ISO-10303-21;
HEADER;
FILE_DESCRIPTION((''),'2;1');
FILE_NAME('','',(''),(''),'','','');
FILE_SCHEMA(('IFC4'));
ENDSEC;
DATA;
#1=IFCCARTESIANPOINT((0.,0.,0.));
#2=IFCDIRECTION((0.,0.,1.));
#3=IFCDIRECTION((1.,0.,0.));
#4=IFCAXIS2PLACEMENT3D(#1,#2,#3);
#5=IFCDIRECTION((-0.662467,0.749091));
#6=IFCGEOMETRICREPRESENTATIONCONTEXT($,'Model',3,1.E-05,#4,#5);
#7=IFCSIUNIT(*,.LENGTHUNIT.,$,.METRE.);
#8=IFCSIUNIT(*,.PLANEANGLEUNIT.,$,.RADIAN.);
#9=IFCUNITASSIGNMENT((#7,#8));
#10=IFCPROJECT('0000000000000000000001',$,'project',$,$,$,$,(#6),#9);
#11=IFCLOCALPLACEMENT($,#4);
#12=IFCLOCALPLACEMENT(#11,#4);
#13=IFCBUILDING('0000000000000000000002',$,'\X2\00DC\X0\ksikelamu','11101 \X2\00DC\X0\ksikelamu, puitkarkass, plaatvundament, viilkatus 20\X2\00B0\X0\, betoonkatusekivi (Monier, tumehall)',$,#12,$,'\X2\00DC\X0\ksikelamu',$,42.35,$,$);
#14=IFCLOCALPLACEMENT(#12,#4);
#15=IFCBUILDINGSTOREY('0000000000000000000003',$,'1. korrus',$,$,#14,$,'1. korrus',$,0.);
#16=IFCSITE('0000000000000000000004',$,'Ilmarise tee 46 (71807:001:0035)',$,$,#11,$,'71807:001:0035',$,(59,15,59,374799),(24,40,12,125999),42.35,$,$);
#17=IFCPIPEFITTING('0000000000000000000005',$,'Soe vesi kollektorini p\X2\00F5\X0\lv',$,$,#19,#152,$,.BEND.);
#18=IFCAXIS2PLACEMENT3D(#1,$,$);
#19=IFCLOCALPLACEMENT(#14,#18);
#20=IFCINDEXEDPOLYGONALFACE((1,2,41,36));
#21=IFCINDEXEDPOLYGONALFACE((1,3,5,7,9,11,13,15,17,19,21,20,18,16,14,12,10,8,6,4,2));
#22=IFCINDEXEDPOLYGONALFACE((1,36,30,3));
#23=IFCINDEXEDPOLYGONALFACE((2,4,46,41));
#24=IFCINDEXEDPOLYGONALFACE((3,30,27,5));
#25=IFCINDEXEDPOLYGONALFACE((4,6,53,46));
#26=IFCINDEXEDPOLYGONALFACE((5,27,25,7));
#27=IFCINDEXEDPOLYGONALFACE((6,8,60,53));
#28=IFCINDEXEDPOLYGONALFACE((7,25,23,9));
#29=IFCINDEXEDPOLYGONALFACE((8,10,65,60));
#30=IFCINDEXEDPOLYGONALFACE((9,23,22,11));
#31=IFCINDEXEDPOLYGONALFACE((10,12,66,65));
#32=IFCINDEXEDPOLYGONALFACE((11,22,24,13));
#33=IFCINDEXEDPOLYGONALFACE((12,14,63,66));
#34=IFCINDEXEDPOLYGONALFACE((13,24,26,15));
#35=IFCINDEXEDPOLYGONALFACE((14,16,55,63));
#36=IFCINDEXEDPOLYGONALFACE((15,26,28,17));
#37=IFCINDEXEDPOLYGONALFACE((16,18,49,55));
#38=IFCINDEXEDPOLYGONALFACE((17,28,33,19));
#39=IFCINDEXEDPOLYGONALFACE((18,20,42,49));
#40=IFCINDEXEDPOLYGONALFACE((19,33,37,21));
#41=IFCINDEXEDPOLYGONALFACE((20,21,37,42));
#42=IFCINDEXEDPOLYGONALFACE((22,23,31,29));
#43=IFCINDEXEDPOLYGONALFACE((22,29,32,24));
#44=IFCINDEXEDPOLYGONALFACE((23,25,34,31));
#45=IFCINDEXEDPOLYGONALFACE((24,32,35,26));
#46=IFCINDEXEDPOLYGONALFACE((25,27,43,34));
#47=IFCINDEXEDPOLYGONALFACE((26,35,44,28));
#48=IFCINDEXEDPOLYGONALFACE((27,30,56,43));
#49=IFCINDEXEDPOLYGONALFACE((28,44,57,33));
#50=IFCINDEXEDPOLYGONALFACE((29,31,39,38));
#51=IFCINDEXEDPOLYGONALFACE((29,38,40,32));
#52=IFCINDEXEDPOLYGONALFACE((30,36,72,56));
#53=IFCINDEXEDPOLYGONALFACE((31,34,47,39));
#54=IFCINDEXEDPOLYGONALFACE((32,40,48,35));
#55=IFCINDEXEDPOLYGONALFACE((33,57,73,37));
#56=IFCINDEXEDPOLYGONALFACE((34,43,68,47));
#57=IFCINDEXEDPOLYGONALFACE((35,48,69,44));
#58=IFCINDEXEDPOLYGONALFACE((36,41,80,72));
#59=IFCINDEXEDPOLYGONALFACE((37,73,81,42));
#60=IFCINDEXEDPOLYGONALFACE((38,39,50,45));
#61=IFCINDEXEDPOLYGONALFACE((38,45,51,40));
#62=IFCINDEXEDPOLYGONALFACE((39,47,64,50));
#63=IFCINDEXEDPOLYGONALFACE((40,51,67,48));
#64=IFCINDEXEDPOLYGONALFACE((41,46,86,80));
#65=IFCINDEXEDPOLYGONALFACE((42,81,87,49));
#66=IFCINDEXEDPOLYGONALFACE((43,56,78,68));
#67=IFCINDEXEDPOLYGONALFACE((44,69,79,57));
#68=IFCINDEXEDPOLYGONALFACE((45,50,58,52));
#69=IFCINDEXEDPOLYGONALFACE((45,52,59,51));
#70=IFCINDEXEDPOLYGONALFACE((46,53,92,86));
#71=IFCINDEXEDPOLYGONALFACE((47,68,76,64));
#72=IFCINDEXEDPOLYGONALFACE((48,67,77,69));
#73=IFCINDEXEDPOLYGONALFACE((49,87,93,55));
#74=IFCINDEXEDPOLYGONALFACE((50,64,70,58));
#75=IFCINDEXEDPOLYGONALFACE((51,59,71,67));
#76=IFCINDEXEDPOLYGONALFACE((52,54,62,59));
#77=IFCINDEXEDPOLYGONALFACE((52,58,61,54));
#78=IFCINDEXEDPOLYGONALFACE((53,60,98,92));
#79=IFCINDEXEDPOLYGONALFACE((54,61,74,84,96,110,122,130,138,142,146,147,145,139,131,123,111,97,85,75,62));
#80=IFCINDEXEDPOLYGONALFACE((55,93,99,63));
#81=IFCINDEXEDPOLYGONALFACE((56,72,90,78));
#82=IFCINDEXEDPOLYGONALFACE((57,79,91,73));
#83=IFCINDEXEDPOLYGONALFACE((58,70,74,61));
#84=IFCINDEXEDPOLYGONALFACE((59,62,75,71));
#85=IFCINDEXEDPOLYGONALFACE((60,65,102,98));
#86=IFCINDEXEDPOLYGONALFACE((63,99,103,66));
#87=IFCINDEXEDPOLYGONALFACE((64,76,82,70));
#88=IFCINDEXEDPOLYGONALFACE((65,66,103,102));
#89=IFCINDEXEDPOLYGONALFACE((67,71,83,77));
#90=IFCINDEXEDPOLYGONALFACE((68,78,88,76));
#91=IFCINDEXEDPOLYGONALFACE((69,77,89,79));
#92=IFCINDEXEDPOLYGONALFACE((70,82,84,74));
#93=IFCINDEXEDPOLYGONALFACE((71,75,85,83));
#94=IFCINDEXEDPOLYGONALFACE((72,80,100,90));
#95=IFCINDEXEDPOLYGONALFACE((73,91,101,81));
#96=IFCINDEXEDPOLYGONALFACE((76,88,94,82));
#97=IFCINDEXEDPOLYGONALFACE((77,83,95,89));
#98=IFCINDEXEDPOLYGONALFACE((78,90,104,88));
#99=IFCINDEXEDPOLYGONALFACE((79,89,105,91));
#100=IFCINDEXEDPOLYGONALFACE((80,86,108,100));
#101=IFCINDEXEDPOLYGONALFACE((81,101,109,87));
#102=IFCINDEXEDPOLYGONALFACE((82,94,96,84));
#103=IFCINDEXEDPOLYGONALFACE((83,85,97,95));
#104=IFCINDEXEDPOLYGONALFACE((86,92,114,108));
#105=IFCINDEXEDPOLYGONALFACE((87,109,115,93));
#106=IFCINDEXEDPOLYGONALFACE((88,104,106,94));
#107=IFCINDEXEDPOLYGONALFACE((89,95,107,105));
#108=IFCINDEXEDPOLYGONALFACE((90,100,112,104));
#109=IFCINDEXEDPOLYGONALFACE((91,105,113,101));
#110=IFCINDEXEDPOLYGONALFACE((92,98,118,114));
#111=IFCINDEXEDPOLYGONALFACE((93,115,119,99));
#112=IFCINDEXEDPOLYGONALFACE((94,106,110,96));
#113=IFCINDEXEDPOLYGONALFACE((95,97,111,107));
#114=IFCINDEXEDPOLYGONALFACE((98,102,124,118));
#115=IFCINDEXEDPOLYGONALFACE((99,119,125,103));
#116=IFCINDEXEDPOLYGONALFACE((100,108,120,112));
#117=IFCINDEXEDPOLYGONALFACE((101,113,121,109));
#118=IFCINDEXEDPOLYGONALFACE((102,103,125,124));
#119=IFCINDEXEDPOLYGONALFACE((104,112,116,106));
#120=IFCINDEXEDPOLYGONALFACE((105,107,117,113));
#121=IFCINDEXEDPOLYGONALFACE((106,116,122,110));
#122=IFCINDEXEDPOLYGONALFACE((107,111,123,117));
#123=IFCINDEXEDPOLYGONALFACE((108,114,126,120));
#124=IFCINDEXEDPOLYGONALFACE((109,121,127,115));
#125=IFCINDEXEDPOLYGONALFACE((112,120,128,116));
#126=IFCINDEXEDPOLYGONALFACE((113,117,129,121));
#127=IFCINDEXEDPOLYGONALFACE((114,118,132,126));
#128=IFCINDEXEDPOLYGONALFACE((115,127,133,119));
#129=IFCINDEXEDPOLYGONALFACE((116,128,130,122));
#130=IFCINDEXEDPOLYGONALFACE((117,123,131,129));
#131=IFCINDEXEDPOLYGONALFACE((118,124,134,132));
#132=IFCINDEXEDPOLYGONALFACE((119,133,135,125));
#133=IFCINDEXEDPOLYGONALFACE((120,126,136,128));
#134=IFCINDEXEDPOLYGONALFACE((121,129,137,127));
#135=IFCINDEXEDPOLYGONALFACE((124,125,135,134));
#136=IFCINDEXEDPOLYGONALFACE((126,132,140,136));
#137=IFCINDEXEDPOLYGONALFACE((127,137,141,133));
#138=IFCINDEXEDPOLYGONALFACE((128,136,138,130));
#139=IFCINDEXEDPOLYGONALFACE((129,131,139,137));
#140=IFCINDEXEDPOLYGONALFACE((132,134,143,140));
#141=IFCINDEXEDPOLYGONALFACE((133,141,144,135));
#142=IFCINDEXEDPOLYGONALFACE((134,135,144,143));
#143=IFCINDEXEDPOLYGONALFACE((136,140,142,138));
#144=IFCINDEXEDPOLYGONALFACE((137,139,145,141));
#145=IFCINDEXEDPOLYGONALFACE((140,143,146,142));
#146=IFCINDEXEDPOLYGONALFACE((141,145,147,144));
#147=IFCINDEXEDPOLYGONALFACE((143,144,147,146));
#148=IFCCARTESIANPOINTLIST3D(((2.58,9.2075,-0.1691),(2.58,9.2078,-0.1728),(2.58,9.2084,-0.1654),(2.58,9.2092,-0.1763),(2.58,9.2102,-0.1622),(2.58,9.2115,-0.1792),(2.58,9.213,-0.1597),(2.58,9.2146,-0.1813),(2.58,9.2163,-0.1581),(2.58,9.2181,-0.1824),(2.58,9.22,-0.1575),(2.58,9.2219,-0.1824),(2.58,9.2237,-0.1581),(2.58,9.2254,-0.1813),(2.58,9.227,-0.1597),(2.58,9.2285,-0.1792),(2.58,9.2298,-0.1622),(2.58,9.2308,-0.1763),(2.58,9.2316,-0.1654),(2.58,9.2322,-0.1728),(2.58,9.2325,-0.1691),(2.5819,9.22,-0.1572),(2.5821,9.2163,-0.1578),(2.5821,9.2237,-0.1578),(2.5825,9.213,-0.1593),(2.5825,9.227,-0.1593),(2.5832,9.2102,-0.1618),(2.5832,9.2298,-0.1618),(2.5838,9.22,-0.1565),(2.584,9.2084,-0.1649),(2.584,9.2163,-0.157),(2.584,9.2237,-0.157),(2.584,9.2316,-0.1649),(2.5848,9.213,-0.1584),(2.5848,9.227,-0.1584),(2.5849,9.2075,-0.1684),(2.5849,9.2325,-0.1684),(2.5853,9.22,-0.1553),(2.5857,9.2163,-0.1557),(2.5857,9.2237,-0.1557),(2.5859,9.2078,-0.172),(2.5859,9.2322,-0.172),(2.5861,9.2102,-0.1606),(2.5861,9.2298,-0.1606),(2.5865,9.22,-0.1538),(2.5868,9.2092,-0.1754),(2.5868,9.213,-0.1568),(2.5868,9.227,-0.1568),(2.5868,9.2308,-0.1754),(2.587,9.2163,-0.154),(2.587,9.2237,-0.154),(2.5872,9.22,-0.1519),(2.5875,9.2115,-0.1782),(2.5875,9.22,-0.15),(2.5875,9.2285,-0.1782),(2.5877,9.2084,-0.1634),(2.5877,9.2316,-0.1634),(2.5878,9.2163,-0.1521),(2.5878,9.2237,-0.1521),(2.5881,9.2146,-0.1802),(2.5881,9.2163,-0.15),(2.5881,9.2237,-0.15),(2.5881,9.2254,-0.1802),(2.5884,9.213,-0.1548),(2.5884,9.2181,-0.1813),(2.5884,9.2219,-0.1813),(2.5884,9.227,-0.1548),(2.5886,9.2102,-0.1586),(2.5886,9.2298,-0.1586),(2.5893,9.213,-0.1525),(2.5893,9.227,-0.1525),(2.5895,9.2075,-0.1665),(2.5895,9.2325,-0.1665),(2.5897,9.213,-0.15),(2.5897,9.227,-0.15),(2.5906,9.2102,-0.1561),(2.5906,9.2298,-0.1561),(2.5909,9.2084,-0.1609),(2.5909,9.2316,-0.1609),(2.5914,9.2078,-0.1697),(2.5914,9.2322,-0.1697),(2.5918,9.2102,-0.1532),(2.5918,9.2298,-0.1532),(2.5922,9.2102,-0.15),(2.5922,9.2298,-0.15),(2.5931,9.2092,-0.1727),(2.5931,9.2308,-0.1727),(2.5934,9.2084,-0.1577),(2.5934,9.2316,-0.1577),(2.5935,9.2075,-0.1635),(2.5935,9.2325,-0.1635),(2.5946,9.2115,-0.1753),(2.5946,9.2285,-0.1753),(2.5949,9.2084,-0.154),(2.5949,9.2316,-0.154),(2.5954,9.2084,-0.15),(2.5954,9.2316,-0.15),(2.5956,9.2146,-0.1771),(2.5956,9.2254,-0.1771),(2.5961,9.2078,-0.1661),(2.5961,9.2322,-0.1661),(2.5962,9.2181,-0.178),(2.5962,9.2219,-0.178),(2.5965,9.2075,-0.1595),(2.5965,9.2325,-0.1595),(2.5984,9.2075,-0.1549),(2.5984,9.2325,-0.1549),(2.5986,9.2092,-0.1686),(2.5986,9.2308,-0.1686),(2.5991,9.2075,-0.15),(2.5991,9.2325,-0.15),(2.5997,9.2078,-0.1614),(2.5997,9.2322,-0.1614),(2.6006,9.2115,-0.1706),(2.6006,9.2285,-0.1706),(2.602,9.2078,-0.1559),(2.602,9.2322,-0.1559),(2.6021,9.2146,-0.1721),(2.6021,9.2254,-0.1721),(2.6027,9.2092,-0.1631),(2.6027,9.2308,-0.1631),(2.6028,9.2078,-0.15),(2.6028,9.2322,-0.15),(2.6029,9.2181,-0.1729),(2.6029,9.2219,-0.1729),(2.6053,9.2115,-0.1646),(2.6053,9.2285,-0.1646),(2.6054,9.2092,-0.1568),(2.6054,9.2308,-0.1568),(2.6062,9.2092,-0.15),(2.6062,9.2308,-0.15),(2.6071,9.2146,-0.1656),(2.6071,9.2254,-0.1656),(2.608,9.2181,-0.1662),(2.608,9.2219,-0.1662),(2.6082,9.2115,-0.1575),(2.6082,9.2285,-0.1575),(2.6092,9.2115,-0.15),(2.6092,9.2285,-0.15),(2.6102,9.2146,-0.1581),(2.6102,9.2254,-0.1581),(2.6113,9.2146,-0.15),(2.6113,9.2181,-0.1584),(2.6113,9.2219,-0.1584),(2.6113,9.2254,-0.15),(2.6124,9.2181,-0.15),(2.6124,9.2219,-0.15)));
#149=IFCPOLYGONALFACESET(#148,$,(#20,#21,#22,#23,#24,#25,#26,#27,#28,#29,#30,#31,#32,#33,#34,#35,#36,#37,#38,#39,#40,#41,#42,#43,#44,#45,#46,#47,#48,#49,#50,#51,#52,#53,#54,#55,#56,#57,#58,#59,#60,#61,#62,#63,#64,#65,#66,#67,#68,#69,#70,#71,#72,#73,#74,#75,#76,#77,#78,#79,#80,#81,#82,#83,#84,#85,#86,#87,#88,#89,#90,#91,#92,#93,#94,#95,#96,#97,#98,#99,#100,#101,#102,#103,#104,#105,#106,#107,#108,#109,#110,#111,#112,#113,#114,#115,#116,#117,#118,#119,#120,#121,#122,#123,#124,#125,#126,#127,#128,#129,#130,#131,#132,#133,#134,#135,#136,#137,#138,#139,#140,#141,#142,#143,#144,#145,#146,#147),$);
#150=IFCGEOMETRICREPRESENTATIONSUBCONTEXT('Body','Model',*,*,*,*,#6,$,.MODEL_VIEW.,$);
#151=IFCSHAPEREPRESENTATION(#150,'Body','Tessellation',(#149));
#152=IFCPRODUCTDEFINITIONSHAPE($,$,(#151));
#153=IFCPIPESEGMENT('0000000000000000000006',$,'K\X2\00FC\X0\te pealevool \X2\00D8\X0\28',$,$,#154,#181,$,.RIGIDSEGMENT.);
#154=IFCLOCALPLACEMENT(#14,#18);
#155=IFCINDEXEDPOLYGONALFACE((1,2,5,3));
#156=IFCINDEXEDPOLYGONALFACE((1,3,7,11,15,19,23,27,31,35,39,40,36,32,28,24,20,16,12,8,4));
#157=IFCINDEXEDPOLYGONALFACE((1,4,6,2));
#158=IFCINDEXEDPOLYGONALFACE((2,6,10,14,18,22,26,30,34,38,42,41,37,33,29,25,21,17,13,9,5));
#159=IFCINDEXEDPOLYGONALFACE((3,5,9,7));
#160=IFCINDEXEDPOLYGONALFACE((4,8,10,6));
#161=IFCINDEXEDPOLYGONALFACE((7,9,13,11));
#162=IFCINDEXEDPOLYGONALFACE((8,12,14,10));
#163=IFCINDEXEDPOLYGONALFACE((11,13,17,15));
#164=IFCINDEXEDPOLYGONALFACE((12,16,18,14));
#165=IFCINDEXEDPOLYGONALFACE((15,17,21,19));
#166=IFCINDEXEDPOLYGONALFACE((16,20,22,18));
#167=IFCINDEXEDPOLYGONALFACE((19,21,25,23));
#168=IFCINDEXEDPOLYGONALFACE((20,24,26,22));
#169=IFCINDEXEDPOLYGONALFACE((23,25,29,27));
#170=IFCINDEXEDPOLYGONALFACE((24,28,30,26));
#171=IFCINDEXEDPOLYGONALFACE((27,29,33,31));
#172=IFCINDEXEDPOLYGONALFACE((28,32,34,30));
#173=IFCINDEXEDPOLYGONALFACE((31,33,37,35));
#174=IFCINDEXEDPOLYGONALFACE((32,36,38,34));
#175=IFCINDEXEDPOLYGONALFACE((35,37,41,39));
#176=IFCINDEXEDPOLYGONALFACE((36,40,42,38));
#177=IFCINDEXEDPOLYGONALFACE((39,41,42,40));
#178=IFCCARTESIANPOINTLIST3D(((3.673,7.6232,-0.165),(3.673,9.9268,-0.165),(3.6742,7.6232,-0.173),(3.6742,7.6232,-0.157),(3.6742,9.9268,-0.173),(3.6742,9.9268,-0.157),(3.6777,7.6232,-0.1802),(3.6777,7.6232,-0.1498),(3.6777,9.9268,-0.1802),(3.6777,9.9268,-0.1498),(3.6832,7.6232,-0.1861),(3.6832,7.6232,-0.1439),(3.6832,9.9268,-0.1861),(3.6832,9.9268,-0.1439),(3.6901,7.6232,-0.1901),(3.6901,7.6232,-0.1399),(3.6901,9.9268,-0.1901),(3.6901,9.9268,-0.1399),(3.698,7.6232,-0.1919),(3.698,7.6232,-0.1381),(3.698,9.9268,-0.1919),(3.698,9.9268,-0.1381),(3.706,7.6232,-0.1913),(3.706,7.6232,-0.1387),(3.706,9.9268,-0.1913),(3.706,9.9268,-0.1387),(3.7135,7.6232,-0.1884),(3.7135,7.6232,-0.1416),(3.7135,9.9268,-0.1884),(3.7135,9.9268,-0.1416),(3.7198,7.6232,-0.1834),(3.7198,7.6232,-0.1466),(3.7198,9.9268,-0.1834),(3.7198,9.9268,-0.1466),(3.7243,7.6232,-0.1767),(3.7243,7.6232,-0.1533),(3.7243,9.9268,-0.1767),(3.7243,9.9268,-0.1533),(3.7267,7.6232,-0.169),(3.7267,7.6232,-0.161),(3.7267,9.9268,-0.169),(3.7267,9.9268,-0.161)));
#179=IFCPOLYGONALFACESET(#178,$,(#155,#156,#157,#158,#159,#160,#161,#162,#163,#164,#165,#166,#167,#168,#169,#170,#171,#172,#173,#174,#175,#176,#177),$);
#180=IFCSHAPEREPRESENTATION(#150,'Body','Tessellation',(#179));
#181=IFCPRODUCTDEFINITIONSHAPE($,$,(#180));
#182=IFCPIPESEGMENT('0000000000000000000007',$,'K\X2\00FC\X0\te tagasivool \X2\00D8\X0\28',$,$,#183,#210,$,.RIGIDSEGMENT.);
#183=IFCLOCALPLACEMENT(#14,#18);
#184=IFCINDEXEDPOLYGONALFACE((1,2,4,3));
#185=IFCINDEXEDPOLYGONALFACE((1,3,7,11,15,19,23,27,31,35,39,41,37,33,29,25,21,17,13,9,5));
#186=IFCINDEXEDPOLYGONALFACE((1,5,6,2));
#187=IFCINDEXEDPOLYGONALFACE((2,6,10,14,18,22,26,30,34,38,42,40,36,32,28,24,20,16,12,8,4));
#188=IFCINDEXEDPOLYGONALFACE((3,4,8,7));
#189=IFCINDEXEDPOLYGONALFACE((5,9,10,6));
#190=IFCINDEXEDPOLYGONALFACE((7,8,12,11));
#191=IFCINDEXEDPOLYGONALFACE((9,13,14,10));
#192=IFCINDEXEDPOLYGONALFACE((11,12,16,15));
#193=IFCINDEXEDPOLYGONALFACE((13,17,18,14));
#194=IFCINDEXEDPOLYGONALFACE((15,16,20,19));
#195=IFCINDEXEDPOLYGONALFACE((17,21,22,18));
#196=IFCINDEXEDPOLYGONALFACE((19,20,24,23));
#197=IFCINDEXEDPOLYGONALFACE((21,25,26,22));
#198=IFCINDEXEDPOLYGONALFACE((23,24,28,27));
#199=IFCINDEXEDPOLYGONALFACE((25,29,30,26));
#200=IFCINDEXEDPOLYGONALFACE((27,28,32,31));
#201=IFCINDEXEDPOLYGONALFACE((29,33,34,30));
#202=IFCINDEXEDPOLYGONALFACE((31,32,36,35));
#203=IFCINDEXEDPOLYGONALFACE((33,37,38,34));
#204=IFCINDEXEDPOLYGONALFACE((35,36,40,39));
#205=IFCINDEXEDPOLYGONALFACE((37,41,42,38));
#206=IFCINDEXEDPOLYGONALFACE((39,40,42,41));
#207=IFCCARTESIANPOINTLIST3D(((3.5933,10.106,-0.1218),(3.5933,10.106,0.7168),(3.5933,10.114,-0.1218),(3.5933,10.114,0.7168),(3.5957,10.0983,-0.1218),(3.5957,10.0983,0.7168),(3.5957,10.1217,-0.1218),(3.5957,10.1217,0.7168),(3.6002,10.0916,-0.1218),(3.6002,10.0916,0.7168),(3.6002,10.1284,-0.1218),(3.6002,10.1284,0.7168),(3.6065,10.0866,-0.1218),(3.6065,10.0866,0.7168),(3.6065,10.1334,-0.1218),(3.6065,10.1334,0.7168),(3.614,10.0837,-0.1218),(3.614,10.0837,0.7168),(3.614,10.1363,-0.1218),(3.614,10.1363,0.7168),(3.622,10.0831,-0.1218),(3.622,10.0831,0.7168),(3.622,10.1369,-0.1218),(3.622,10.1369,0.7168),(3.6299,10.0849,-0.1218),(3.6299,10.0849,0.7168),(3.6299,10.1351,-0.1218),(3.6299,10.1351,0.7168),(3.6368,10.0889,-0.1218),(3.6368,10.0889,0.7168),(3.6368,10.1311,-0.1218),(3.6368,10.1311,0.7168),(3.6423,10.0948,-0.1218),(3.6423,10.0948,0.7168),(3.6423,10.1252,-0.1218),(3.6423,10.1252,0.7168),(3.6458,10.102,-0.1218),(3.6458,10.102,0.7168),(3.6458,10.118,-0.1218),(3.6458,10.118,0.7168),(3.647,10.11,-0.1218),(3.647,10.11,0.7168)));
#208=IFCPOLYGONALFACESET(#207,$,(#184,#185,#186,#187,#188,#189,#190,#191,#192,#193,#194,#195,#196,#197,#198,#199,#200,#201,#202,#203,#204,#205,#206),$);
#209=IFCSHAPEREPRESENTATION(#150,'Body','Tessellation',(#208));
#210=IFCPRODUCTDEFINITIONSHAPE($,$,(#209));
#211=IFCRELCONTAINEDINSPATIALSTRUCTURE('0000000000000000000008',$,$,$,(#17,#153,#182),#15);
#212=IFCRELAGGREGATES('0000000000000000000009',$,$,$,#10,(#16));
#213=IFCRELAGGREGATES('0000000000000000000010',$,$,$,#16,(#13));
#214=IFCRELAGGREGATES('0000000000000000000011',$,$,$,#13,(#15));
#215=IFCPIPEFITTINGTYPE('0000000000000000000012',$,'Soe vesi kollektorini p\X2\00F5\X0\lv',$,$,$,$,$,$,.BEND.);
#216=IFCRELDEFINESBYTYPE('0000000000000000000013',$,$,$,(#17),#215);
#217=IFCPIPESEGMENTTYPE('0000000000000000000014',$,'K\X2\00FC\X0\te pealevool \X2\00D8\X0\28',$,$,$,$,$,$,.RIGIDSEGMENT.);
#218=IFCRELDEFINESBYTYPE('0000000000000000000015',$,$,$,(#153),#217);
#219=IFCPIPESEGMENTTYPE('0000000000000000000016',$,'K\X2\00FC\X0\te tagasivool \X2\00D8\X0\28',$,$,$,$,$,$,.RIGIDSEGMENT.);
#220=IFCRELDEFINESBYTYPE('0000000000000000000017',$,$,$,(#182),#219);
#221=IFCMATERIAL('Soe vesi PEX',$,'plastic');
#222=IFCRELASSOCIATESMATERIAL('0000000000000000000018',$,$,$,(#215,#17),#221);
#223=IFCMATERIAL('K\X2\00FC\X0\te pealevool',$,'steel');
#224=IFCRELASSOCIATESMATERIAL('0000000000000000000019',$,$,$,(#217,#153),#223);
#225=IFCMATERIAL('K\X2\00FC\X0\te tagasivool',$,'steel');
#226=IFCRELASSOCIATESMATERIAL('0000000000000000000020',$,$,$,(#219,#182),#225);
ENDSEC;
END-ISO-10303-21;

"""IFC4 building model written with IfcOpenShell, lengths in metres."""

from ifc_helpers import new_model, entity, si_unit, direction, frame, origin_with_axes, place, context, subcontext, project, spatial, circle, extrude, material, type_object, element, save


model = new_model("IFC4")

# Units and contexts
model_context = context("Model", 3, precision=1e-05, world=origin_with_axes(), true_north=direction((-0.662467, 0.749091)))
body_context = subcontext(model_context, "Body", "Model", "MODEL_VIEW")
ifc_project = project(units=[si_unit("LENGTHUNIT", "METRE"), si_unit("PLANEANGLEUNIT", "RADIAN")], contexts=[model_context])

# Site, building, storey
site_placement = place(None, origin_with_axes())
site = spatial("IfcSite", under=ifc_project, at=site_placement, Name="Ilmarise tee 46 (71807:001:0035)", LongName="71807:001:0035", RefLatitude=(59, 15, 59, 374799), RefLongitude=(24, 40, 12, 125999), RefElevation=42.35)
building_placement = place(site_placement, origin_with_axes())
building = spatial("IfcBuilding", under=site, at=building_placement, Name="Üksikelamu", Description="11101 Üksikelamu, puitkarkass, plaatvundament, viilkatus 20°, betoonkatusekivi (Monier, tumehall)", LongName="Üksikelamu", ElevationOfRefHeight=42.35)
storey_placement = place(building_placement, origin_with_axes())
storey = spatial("IfcBuildingStorey", under=building, at=storey_placement, Name="1. korrus", LongName="1. korrus", Elevation=0.0)

# Pipe fitting
ifc_material_1 = material(Name="Küte pealevool", Category="steel")
ifc_material_2 = material(Name="Küte tagasivool", Category="steel")
ifc_material_3 = material(Name="Soe vesi PEX", Category="plastic")
pipe_fitting_type_1 = type_object("IfcPipeFittingType", Name="Soe vesi kollektorini põlv", PredefinedType="BEND", material=ifc_material_3)
pipe_fitting_1_placement = place(storey_placement, frame((2.6, 9.22, -0.17), z_axis=(0.0, 0.0, 1.0), x_axis=(1.0, 0.0, 0.0)))
element("IfcPipeFitting", 1, at=pipe_fitting_1_placement, inside=storey, type_object=pipe_fitting_type_1, material=ifc_material_3, Name="Soe vesi kollektorini põlv", PredefinedType="BEND", context=body_context, shape_type="SweptSolid", body=[
    entity("IfcRevolvedAreaSolid", entity("IfcCircleProfileDef", "AREA", None, None, 0.0125), entity("IfcAxis2Placement3D", entity("IfcCartesianPoint", [0.0, 0.0, 0.02]), entity("IfcDirection", [0.0, 0.0, -1.0]), entity("IfcDirection", [-1.0, 0.0, 0.0])), entity("IfcAxis1Placement", entity("IfcCartesianPoint", [0.02, 0.0, 0.0]), entity("IfcDirection", [0.0, 1.0, 0.0])), 1.570796),
])

# Pipe segments
pipe_segment_type_1 = type_object("IfcPipeSegmentType", Name="Küte pealevool Ø28", PredefinedType="RIGIDSEGMENT", material=ifc_material_1)
pipe_segment_1_placement = place(storey_placement, frame((3.7, 9.9268, -0.165), z_axis=(0.0, -1.0, 0.0), x_axis=(-1.0, 0.0, 0.0)))
element("IfcPipeSegment", 2, at=pipe_segment_1_placement, inside=storey, type_object=pipe_segment_type_1, material=ifc_material_1, Name="Küte pealevool Ø28", PredefinedType="RIGIDSEGMENT", context=body_context, shape_type="SweptSolid", body=[
    extrude(circle(Radius=0.027), origin_with_axes(), (0.0, 0.0, 1.0), 2.3036),
])
pipe_segment_type_2 = type_object("IfcPipeSegmentType", Name="Küte tagasivool Ø28", PredefinedType="RIGIDSEGMENT", material=ifc_material_2)
pipe_segment_2_placement = place(storey_placement, frame((3.62, 10.11, -0.1218), z_axis=(0.0, 0.0, 1.0), x_axis=(1.0, 0.0, 0.0)))
element("IfcPipeSegment", 3, at=pipe_segment_2_placement, inside=storey, type_object=pipe_segment_type_2, material=ifc_material_2, Name="Küte tagasivool Ø28", PredefinedType="RIGIDSEGMENT", context=body_context, shape_type="SweptSolid", body=[
    extrude(circle(Radius=0.027), origin_with_axes(), (0.0, 0.0, 1.0), 0.8386),
])

save(model, "model.ifc")
